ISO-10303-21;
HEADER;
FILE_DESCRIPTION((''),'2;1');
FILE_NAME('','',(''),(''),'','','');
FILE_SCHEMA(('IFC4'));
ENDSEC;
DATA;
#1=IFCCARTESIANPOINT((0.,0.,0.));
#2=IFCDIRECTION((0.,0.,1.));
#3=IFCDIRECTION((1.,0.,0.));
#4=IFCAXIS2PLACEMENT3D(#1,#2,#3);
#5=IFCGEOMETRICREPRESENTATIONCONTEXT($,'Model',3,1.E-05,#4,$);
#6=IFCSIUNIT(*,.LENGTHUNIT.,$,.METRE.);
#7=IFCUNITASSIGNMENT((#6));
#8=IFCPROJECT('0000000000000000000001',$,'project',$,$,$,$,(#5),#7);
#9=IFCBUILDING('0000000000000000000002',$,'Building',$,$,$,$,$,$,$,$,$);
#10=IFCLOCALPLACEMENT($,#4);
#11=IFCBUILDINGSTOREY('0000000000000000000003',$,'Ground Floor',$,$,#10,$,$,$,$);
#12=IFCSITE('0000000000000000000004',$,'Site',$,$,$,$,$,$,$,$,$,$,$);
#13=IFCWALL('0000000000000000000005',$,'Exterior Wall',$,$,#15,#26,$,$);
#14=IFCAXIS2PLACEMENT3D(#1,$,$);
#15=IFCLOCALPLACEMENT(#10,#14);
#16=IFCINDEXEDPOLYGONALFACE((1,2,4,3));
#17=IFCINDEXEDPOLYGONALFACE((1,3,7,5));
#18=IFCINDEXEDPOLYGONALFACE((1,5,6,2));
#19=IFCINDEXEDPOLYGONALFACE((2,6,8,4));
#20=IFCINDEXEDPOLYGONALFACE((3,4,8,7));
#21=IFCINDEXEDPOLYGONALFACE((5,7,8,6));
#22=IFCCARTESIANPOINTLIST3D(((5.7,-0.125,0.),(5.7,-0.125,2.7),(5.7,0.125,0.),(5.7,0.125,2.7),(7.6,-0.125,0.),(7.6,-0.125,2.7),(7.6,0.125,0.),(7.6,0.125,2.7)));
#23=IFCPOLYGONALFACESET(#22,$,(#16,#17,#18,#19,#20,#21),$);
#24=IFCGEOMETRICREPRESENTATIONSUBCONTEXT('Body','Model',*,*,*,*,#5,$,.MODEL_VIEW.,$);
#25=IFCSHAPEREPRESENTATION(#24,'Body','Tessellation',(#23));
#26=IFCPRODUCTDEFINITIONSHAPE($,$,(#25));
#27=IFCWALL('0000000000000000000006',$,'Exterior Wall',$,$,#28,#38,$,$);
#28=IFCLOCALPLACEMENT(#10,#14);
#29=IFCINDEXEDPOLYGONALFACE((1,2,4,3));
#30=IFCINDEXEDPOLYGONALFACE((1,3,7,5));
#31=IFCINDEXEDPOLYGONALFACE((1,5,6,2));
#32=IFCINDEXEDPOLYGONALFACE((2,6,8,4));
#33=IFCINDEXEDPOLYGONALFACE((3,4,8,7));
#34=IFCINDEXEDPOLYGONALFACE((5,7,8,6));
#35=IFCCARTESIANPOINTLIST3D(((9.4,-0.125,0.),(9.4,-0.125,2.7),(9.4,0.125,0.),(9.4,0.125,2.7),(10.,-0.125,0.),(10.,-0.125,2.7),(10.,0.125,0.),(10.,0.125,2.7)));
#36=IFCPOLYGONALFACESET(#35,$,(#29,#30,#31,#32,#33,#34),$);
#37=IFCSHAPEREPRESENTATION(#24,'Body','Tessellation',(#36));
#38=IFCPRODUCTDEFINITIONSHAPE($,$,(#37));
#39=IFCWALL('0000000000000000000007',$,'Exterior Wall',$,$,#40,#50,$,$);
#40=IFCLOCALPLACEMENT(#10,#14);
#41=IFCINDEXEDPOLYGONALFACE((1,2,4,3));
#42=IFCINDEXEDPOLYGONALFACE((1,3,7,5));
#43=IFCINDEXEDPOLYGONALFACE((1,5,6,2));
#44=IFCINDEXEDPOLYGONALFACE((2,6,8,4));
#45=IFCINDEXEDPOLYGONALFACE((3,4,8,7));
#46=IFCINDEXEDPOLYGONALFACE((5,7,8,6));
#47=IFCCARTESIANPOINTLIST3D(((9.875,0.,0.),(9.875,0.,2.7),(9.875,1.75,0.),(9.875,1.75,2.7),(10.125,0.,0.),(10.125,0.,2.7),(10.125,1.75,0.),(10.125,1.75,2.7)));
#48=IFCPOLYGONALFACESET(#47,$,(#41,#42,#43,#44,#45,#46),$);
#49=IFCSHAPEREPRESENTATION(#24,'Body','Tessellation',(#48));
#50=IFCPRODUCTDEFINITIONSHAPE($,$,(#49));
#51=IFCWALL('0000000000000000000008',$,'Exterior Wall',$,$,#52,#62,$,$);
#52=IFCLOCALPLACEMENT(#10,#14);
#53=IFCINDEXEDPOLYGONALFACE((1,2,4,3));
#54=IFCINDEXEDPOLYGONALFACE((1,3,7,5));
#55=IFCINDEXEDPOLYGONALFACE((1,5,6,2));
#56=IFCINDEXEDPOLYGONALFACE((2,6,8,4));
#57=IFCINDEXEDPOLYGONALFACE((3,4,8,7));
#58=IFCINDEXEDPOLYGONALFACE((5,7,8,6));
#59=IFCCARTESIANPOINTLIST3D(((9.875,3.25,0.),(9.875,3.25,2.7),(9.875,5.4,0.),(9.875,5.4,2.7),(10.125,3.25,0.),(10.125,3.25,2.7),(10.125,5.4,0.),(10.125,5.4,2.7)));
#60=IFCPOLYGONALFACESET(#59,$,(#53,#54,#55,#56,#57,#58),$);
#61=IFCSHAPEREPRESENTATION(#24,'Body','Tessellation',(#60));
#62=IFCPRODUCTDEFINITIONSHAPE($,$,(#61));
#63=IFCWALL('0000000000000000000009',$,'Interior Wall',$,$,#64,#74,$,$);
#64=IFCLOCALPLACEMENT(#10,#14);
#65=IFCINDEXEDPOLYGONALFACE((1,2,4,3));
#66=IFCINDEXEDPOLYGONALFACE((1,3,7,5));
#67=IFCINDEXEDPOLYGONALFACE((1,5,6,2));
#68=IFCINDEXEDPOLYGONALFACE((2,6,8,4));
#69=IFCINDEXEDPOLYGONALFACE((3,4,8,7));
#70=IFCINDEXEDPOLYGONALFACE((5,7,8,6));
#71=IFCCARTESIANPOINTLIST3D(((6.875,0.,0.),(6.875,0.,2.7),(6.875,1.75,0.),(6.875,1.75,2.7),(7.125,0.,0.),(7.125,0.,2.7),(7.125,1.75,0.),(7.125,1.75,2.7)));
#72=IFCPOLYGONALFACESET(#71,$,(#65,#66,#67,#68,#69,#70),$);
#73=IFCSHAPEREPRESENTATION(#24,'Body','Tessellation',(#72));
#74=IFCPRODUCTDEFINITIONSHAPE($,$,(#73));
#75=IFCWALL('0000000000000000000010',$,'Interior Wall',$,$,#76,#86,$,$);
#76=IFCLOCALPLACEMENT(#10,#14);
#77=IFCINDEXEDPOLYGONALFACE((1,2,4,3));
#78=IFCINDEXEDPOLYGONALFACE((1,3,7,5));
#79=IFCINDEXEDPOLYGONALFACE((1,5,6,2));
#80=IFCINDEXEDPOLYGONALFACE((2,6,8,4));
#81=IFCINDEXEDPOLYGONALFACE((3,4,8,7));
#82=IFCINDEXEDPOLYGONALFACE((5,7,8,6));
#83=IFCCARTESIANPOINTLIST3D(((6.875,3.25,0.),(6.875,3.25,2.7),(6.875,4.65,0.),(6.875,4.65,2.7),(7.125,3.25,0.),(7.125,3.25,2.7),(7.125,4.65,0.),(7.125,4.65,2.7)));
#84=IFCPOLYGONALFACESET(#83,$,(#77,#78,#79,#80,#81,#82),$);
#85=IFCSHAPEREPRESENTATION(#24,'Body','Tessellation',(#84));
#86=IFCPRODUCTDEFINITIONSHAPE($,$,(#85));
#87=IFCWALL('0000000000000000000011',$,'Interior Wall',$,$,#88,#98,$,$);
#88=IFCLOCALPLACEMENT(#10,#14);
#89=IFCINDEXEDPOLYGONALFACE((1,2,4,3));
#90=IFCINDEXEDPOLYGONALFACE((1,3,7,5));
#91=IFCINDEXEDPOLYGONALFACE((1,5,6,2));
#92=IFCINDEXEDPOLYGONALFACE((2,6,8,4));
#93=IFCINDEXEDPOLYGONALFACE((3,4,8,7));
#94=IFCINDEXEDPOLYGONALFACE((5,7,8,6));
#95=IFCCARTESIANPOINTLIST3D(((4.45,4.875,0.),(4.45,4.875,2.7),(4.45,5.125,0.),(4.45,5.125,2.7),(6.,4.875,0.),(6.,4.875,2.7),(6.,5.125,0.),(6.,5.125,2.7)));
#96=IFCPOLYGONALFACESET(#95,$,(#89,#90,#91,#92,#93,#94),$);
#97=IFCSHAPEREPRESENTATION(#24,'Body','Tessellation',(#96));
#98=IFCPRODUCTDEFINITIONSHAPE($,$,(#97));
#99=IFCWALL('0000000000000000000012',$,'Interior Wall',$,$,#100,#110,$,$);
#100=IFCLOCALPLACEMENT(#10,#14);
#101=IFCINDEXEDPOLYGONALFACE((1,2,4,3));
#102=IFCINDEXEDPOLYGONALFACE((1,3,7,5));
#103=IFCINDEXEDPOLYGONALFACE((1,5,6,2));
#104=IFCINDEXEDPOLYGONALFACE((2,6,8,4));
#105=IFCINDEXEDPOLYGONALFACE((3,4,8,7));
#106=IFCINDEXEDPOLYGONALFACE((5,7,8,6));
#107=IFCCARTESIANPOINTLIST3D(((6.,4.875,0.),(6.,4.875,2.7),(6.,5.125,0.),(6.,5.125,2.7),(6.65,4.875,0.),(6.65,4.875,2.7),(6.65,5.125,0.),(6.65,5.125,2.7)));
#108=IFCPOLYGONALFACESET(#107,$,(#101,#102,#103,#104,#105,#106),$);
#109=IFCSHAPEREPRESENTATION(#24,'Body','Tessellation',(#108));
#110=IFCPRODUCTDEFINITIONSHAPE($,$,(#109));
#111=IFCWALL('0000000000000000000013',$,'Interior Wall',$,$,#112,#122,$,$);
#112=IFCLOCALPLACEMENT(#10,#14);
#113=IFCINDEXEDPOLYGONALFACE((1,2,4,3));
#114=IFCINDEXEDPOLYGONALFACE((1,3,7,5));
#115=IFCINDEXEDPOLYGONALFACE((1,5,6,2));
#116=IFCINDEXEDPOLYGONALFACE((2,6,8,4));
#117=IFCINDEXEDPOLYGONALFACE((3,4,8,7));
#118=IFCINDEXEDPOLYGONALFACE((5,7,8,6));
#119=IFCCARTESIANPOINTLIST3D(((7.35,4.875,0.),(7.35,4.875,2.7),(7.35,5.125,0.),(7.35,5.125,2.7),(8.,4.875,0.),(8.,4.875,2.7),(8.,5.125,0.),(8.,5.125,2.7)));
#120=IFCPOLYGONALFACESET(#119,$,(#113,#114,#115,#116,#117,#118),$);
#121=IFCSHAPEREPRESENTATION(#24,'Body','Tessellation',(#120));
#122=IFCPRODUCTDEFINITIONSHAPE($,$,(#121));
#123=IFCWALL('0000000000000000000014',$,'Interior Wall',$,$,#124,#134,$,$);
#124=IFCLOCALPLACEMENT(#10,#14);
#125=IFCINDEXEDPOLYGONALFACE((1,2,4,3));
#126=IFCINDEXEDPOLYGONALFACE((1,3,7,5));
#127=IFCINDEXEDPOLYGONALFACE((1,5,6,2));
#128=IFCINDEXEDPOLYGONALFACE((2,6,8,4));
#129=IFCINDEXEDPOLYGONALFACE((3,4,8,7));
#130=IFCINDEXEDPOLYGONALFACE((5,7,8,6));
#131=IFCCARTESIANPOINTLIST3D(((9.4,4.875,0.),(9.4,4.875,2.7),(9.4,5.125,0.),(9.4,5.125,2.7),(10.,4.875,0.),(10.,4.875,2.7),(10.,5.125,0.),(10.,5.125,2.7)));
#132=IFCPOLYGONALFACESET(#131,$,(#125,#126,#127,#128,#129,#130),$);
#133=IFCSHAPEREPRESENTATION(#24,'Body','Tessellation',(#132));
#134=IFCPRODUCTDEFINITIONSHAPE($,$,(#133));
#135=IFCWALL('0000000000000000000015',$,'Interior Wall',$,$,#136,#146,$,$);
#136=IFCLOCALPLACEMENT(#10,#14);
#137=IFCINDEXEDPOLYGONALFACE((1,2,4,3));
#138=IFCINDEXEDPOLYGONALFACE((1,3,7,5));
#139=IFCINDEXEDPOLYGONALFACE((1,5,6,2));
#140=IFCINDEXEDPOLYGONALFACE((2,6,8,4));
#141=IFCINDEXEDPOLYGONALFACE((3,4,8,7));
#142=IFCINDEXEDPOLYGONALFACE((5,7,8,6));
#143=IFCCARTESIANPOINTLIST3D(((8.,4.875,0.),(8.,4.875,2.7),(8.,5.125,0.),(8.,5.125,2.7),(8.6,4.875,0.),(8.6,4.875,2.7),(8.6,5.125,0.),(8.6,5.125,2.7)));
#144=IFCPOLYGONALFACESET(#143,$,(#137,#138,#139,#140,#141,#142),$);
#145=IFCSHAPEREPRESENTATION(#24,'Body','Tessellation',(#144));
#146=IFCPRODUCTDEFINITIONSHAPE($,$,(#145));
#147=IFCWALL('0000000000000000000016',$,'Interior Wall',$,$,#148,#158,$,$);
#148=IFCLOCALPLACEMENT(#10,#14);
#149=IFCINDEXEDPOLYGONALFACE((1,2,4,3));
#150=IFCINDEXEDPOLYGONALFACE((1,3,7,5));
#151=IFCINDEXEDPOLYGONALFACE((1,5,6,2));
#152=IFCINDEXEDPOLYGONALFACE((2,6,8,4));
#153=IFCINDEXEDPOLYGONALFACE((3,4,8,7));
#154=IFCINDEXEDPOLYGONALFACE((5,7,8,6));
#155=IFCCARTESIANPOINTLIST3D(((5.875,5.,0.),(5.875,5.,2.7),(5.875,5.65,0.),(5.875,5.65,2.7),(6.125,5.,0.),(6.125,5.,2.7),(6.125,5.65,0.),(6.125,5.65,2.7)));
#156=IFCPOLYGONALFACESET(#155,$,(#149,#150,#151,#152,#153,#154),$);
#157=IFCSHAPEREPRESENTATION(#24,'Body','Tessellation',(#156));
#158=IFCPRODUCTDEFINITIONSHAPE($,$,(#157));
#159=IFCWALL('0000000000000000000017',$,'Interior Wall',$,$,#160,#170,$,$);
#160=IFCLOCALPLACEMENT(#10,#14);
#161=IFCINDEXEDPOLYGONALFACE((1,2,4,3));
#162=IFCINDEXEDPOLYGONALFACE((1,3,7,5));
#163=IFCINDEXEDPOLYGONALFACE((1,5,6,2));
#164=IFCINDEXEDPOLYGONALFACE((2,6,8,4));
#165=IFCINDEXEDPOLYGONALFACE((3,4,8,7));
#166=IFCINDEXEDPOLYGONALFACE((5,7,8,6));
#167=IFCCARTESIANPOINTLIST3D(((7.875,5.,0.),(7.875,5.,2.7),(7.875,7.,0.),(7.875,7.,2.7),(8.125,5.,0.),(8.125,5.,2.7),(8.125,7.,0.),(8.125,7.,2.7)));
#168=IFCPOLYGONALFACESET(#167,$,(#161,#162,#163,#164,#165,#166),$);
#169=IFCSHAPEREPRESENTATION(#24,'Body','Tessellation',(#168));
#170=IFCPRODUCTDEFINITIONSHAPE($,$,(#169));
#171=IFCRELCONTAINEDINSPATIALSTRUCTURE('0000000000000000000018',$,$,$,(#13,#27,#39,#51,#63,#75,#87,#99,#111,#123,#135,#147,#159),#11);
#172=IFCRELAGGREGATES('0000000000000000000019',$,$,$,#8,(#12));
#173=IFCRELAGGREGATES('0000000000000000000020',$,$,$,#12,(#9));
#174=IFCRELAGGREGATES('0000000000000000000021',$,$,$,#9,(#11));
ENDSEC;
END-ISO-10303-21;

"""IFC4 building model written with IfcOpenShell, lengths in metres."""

from ifc_helpers import new_model, si_unit, frame, origin_with_axes, place, context, subcontext, project, spatial, indexed_curve, outline, extrude, element, save


model = new_model("IFC4")

# Units and contexts
model_context = context("Model", 3, precision=1e-05, world=origin_with_axes())
body_context = subcontext(model_context, "Body", "Model", "MODEL_VIEW")
ifc_project = project(units=[si_unit("LENGTHUNIT", "METRE")], contexts=[model_context])

# Site, building, storey
site = spatial("IfcSite", under=ifc_project, Name="Site")
building = spatial("IfcBuilding", under=site, Name="Building")
storey_placement = place(None, origin_with_axes())
storey = spatial("IfcBuildingStorey", under=building, at=storey_placement, Name="Ground Floor")

# Walls
wall_1_placement = place(storey_placement, frame((5.7, 0.0, 0.0), z_axis=(0.0, 0.0, 1.0), x_axis=(1.0, 0.0, 0.0)))
element("IfcWall", 1, at=wall_1_placement, inside=storey, Name="Exterior Wall", context=body_context, shape_type="SweptSolid", body=[
    extrude(outline(indexed_curve([(0.0, 0.0), (0.0, 0.25), (1.9, 0.25), (1.9, 0.0), (0.0, 0.0)], self_intersect=False)), frame((0.0, -0.125, 0.0), z_axis=(0.0, 0.0, 1.0), x_axis=(1.0, 0.0, 0.0)), (0.0, 0.0, 1.0), 2.7),
])
wall_2_placement = place(storey_placement, frame((9.4, 0.0, 0.0), z_axis=(0.0, 0.0, 1.0), x_axis=(1.0, 0.0, 0.0)))
element("IfcWall", 2, at=wall_2_placement, inside=storey, Name="Exterior Wall", context=body_context, shape_type="SweptSolid", body=[
    extrude(outline(indexed_curve([(0.0, 0.0), (0.0, 0.25), (0.6, 0.25), (0.6, 0.0), (0.0, 0.0)], self_intersect=False)), frame((0.0, -0.125, 0.0), z_axis=(0.0, 0.0, 1.0), x_axis=(1.0, 0.0, 0.0)), (0.0, 0.0, 1.0), 2.7),
])
wall_3_placement = place(storey_placement, frame((10.0, 0.0, 0.0), z_axis=(0.0, 0.0, 1.0), x_axis=(0.0, 1.0, 0.0)))
element("IfcWall", 3, at=wall_3_placement, inside=storey, Name="Exterior Wall", context=body_context, shape_type="SweptSolid", body=[
    extrude(outline(indexed_curve([(0.0, 0.0), (0.0, 0.25), (1.75, 0.25), (1.75, 0.0), (0.0, 0.0)], self_intersect=False)), frame((0.0, -0.125, 0.0), z_axis=(0.0, 0.0, 1.0), x_axis=(1.0, 0.0, 0.0)), (0.0, 0.0, 1.0), 2.7),
])
wall_4_placement = place(storey_placement, frame((10.0, 3.25, 0.0), z_axis=(0.0, 0.0, 1.0), x_axis=(0.0, 1.0, 0.0)))
element("IfcWall", 4, at=wall_4_placement, inside=storey, Name="Exterior Wall", context=body_context, shape_type="SweptSolid", body=[
    extrude(outline(indexed_curve([(0.0, 0.0), (0.0, 0.25), (2.15, 0.25), (2.15, 0.0), (0.0, 0.0)], self_intersect=False)), frame((0.0, -0.125, 0.0), z_axis=(0.0, 0.0, 1.0), x_axis=(1.0, 0.0, 0.0)), (0.0, 0.0, 1.0), 2.7),
])
wall_5_placement = place(storey_placement, frame((7.0, 0.0, 0.0), z_axis=(0.0, 0.0, 1.0), x_axis=(0.0, 1.0, 0.0)))
element("IfcWall", 5, at=wall_5_placement, inside=storey, Name="Interior Wall", context=body_context, shape_type="SweptSolid", body=[
    extrude(outline(indexed_curve([(0.0, 0.0), (0.0, 0.25), (1.75, 0.25), (1.75, 0.0), (0.0, 0.0)], self_intersect=False)), frame((0.0, -0.125, 0.0), z_axis=(0.0, 0.0, 1.0), x_axis=(1.0, 0.0, 0.0)), (0.0, 0.0, 1.0), 2.7),
])
wall_6_placement = place(storey_placement, frame((7.0, 3.25, 0.0), z_axis=(0.0, 0.0, 1.0), x_axis=(0.0, 1.0, 0.0)))
element("IfcWall", 6, at=wall_6_placement, inside=storey, Name="Interior Wall", context=body_context, shape_type="SweptSolid", body=[
    extrude(outline(indexed_curve([(0.0, 0.0), (0.0, 0.25), (1.4, 0.25), (1.4, 0.0), (0.0, 0.0)], self_intersect=False)), frame((0.0, -0.125, 0.0), z_axis=(0.0, 0.0, 1.0), x_axis=(1.0, 0.0, 0.0)), (0.0, 0.0, 1.0), 2.7),
])
wall_7_placement = place(storey_placement, frame((6.0, 5.0, 0.0), z_axis=(0.0, 0.0, 1.0), x_axis=(-1.0, 0.0, 0.0)))
element("IfcWall", 7, at=wall_7_placement, inside=storey, Name="Interior Wall", context=body_context, shape_type="SweptSolid", body=[
    extrude(outline(indexed_curve([(0.0, 0.0), (0.0, 0.25), (1.55, 0.25), (1.55, 0.0), (0.0, 0.0)], self_intersect=False)), frame((0.0, -0.125, 0.0), z_axis=(0.0, 0.0, 1.0), x_axis=(1.0, 0.0, 0.0)), (0.0, 0.0, 1.0), 2.7),
])
for number, where, z_axis, x_axis, name in (
    (8, (6.65, 5.0, 0.0), (0.0, 0.0, 1.0), (-1.0, 0.0, 0.0), "Interior Wall"),
    (9, (8.0, 5.0, 0.0), (0.0, 0.0, 1.0), (-1.0, 0.0, 0.0), "Interior Wall"),
):
    element("IfcWall", number, at=place(storey_placement, frame(where, z_axis=z_axis, x_axis=x_axis)), inside=storey, Name=name, context=body_context, shape_type="SweptSolid", body=[
        extrude(outline(indexed_curve([(0.0, 0.0), (0.0, 0.25), (0.65, 0.25), (0.65, 0.0), (0.0, 0.0)], self_intersect=False)), frame((0.0, -0.125, 0.0), z_axis=(0.0, 0.0, 1.0), x_axis=(1.0, 0.0, 0.0)), (0.0, 0.0, 1.0), 2.7),
    ])
for number, where, z_axis, x_axis, name in (
    (10, (10.0, 5.0, 0.0), (0.0, 0.0, 1.0), (-1.0, 0.0, 0.0), "Interior Wall"),
    (11, (8.6, 5.0, 0.0), (0.0, 0.0, 1.0), (-1.0, 0.0, 0.0), "Interior Wall"),
):
    element("IfcWall", number, at=place(storey_placement, frame(where, z_axis=z_axis, x_axis=x_axis)), inside=storey, Name=name, context=body_context, shape_type="SweptSolid", body=[
        extrude(outline(indexed_curve([(0.0, 0.0), (0.0, 0.25), (0.6, 0.25), (0.6, 0.0), (0.0, 0.0)], self_intersect=False)), frame((0.0, -0.125, 0.0), z_axis=(0.0, 0.0, 1.0), x_axis=(1.0, 0.0, 0.0)), (0.0, 0.0, 1.0), 2.7),
    ])
wall_8_placement = place(storey_placement, frame((6.0, 5.0, 0.0), z_axis=(0.0, 0.0, 1.0), x_axis=(0.0, 1.0, 0.0)))
element("IfcWall", 12, at=wall_8_placement, inside=storey, Name="Interior Wall", context=body_context, shape_type="SweptSolid", body=[
    extrude(outline(indexed_curve([(0.0, 0.0), (0.0, 0.25), (0.65, 0.25), (0.65, 0.0), (0.0, 0.0)], self_intersect=False)), frame((0.0, -0.125, 0.0), z_axis=(0.0, 0.0, 1.0), x_axis=(1.0, 0.0, 0.0)), (0.0, 0.0, 1.0), 2.7),
])
wall_9_placement = place(storey_placement, frame((8.0, 5.0, 0.0), z_axis=(0.0, 0.0, 1.0), x_axis=(0.0, 1.0, 0.0)))
element("IfcWall", 13, at=wall_9_placement, inside=storey, Name="Interior Wall", context=body_context, shape_type="SweptSolid", body=[
    extrude(outline(indexed_curve([(0.0, 0.0), (0.0, 0.25), (2.0, 0.25), (2.0, 0.0), (0.0, 0.0)], self_intersect=False)), frame((0.0, -0.125, 0.0), z_axis=(0.0, 0.0, 1.0), x_axis=(1.0, 0.0, 0.0)), (0.0, 0.0, 1.0), 2.7),
])

save(model, "model.ifc")
